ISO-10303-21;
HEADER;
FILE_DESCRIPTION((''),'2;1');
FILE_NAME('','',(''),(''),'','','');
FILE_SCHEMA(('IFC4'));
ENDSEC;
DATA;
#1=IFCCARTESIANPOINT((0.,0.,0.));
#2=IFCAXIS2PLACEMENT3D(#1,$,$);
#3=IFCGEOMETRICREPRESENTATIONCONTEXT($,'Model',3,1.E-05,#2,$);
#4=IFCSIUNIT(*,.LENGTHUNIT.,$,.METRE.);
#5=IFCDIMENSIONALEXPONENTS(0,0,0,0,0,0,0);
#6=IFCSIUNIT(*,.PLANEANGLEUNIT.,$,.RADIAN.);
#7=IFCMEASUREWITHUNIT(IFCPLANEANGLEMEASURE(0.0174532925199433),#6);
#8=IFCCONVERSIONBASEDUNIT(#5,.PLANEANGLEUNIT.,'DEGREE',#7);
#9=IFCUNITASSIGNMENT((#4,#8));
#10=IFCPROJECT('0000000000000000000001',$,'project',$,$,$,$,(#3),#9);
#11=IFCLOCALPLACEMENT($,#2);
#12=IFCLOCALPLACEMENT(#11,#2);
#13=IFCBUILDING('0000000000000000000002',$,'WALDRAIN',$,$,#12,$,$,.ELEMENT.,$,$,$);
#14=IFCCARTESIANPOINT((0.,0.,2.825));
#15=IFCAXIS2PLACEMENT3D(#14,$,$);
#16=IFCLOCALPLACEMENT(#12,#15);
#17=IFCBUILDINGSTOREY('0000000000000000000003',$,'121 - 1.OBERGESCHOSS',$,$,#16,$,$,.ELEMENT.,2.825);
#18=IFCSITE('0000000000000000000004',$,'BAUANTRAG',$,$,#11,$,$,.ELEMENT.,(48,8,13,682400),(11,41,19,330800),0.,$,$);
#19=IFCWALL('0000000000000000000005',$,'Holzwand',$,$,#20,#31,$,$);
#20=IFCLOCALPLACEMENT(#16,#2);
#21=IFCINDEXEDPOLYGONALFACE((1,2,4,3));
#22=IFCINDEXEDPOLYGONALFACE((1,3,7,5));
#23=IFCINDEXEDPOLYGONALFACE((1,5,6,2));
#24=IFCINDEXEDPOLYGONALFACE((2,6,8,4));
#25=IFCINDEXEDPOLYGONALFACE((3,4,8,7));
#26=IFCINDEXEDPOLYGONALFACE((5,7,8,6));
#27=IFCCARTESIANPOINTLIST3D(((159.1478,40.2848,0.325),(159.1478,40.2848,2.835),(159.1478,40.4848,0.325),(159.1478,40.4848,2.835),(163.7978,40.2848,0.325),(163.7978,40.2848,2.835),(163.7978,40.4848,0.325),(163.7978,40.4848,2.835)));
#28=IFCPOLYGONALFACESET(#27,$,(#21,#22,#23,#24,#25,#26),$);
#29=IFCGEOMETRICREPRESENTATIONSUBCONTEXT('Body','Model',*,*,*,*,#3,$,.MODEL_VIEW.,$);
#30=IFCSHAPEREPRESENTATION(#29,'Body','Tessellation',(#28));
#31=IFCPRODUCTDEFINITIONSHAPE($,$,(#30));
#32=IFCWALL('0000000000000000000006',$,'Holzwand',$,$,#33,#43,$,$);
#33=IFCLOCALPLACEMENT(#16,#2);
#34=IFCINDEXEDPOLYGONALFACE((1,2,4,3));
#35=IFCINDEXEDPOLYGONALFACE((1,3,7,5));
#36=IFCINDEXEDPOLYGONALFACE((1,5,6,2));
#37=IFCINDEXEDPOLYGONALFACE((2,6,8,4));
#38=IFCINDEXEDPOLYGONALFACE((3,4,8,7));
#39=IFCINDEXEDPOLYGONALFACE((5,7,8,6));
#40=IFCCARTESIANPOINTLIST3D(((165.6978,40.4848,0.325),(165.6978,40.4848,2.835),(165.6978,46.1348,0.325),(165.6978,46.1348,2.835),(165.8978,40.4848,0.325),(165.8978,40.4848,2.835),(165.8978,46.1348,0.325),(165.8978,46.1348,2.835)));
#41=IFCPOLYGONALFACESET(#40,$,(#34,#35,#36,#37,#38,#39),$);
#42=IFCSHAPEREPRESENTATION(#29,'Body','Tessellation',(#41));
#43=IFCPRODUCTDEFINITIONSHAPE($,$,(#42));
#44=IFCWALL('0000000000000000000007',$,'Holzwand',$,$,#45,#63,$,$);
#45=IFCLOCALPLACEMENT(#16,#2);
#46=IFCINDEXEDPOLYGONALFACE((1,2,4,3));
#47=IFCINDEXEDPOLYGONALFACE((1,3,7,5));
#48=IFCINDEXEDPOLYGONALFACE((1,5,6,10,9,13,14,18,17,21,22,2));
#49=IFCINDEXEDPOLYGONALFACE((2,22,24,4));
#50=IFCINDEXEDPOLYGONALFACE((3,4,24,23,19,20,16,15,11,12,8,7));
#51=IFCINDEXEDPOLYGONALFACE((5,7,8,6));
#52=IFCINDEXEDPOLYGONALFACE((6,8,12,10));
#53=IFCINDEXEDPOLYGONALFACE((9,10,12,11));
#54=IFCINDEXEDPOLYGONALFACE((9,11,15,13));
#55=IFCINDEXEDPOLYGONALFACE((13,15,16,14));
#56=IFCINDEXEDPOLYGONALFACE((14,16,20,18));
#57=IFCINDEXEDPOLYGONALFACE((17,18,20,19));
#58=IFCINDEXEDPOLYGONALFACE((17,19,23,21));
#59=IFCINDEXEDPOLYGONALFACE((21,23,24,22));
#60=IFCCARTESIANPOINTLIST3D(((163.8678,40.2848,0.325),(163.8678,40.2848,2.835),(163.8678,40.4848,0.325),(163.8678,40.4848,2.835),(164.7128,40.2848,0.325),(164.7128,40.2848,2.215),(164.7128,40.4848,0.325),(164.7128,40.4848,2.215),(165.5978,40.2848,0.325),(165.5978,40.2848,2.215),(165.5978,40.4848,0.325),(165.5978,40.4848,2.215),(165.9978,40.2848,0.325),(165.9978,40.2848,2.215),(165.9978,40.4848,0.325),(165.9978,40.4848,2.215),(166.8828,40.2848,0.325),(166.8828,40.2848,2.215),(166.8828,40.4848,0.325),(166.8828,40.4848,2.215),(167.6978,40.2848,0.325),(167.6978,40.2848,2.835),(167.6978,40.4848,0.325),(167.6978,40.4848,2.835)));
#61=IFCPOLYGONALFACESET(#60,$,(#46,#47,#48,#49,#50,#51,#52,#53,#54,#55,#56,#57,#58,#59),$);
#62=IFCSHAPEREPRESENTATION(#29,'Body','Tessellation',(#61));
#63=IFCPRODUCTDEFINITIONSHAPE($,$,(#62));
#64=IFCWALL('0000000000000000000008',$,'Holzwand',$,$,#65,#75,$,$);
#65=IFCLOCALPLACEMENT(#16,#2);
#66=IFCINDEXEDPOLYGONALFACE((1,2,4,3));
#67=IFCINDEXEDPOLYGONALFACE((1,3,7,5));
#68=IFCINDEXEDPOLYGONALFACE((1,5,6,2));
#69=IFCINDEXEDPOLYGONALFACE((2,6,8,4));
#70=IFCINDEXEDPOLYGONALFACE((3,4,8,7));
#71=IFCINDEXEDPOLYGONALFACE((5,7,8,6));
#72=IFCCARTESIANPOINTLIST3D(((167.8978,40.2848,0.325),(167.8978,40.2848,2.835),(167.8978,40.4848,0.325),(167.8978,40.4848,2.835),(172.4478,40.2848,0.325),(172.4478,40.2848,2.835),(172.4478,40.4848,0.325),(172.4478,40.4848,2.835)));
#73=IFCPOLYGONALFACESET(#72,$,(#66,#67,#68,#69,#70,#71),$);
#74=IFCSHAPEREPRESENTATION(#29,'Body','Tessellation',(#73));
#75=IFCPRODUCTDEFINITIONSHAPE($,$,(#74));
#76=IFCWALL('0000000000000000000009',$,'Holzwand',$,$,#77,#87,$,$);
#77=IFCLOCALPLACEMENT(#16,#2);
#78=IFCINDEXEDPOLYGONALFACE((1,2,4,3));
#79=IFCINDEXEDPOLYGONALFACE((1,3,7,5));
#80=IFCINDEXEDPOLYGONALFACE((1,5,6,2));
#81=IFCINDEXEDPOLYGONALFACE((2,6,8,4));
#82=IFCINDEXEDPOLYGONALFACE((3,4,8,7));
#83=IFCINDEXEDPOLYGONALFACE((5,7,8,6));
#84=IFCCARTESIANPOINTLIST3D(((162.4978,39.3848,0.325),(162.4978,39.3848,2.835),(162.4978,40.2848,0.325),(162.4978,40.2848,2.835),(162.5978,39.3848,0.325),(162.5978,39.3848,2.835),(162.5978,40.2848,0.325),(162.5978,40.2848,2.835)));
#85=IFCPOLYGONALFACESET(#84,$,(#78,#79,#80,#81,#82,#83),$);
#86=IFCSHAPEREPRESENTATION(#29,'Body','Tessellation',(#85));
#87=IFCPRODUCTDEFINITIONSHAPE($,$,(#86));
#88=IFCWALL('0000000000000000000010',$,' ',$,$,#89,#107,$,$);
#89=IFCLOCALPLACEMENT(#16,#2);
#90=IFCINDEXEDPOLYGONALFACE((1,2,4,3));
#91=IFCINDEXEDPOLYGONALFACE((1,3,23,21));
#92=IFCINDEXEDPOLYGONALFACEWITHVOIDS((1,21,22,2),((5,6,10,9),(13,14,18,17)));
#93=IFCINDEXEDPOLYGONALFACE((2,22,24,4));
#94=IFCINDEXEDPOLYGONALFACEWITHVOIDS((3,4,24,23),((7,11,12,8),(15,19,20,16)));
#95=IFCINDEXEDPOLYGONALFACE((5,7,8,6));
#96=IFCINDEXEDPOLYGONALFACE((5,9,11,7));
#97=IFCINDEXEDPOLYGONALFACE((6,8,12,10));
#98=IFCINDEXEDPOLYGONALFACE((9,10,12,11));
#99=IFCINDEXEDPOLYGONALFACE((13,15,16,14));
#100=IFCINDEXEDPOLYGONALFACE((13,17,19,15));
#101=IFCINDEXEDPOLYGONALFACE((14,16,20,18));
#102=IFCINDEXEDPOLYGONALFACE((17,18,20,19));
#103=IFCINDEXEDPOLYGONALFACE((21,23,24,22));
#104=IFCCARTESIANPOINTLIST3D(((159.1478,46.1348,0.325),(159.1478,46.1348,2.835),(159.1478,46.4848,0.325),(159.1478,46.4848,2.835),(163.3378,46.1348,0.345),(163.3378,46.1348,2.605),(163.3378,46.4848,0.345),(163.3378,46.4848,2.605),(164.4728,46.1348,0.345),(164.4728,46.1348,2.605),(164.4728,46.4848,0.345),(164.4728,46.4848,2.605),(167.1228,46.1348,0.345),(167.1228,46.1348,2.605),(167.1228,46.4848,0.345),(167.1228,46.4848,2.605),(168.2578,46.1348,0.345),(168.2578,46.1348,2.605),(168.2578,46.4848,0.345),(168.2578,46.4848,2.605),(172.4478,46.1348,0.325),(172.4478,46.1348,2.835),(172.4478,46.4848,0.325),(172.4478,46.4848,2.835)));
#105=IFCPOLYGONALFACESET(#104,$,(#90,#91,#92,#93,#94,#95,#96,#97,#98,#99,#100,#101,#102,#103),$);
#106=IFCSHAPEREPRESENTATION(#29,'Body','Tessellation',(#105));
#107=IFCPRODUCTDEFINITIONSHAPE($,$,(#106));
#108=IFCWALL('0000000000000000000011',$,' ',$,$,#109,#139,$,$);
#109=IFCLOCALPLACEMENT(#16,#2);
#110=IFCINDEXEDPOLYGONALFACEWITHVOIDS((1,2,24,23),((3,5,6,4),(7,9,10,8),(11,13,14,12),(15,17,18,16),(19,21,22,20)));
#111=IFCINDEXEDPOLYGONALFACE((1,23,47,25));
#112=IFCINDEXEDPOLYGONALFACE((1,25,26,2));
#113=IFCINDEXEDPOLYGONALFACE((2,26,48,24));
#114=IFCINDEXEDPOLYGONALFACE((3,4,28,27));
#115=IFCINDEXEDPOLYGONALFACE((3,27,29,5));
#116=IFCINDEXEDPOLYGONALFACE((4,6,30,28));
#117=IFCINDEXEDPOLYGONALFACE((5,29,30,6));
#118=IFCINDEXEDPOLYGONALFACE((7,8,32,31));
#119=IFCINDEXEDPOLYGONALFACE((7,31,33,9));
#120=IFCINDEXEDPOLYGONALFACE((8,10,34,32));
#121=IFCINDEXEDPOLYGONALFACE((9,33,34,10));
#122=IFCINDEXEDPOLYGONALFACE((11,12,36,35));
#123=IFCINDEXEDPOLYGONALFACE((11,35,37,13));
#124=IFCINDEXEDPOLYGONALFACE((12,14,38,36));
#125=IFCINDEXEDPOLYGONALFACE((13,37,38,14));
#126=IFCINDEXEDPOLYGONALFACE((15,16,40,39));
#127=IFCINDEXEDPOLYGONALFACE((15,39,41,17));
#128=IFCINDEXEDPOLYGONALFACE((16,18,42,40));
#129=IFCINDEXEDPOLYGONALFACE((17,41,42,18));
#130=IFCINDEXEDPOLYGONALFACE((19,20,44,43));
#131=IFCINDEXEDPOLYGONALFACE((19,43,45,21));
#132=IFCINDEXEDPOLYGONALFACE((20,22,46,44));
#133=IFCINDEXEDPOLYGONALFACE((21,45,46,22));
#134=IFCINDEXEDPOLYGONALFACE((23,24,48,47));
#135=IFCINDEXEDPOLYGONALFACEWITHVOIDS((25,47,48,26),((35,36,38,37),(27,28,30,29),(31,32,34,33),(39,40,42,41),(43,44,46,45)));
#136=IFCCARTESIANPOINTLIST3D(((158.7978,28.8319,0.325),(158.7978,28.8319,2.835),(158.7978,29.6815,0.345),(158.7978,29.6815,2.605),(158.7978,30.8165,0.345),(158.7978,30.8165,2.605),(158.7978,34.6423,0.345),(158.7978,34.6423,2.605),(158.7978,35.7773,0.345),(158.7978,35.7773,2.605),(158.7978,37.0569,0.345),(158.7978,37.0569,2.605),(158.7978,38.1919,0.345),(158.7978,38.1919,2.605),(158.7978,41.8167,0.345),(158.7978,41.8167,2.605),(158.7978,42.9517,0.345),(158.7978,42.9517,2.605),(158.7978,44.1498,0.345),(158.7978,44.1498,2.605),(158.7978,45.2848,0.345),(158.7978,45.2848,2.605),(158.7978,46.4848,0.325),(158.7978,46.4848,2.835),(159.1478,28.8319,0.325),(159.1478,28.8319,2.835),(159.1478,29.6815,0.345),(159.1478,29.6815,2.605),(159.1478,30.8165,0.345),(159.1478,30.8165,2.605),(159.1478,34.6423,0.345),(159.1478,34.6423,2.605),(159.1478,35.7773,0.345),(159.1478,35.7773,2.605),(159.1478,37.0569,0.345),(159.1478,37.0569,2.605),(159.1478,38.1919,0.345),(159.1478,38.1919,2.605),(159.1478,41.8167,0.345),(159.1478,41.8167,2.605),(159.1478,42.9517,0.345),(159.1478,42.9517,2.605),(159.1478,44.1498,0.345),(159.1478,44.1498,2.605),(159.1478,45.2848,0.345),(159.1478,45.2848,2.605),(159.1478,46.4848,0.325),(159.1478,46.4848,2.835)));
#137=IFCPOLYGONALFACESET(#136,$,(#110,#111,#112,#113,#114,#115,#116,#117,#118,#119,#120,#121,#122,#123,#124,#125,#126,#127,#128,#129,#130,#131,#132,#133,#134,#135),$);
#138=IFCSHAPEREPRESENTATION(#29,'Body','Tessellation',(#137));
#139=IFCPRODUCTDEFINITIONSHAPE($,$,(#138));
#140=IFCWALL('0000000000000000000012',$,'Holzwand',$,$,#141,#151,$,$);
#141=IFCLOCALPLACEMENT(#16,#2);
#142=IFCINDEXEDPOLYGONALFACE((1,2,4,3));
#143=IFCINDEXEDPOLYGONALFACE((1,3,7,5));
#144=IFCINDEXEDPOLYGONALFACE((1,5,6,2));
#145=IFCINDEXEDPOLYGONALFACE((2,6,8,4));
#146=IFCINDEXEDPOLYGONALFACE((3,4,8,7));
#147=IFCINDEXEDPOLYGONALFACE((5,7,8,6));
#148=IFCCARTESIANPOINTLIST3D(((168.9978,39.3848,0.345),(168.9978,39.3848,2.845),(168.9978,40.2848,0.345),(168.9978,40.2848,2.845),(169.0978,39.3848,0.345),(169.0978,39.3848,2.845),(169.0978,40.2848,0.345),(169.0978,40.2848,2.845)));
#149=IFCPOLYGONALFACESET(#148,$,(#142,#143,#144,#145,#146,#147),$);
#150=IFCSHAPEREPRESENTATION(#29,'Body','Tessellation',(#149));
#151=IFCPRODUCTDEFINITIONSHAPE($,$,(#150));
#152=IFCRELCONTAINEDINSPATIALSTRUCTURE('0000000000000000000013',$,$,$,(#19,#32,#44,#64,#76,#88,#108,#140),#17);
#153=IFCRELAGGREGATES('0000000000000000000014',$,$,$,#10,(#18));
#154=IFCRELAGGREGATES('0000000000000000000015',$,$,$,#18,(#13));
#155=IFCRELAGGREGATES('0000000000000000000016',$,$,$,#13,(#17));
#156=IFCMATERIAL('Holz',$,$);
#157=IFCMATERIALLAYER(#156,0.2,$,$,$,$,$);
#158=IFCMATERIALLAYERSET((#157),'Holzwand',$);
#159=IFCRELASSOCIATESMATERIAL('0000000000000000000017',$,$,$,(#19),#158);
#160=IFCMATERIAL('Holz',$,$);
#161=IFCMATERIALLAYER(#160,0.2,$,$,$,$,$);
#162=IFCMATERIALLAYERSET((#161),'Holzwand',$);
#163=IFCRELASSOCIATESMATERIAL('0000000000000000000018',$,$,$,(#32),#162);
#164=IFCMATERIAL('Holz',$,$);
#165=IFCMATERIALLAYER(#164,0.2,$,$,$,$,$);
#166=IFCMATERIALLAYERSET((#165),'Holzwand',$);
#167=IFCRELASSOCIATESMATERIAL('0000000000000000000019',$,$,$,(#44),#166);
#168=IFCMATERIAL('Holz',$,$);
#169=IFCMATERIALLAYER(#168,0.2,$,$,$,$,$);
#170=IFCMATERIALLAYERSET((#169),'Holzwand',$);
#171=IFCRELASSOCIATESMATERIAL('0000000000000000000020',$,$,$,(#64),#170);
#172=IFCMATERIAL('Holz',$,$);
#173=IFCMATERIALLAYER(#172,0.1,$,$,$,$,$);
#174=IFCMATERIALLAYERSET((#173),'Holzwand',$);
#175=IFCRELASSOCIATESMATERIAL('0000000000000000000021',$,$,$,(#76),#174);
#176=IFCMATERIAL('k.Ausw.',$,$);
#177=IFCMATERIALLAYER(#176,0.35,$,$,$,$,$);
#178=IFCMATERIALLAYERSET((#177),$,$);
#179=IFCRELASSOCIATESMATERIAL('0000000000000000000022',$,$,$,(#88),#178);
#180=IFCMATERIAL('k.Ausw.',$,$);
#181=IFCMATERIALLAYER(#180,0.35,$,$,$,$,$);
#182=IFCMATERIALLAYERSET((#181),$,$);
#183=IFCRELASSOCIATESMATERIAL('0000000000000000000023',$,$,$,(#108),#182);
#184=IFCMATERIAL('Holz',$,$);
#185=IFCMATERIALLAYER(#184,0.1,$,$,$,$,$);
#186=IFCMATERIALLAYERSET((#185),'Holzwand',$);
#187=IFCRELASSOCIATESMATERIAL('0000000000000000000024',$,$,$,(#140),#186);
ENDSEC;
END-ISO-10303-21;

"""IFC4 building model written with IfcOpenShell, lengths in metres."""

from ifc_helpers import new_model, entity, si_unit, converted_unit, frame, frame_2d, origin, origin_with_axes, place, context, subcontext, project, spatial, polyline, rectangle, outline, extrude, material, layer, layer_set, layer_usage, element, save


model = new_model("IFC4")

# Units and contexts
model_context = context("Model", 3, precision=1e-05, world=origin())
body_context = subcontext(model_context, "Body", "Model", "MODEL_VIEW")
ifc_project = project(units=[si_unit("LENGTHUNIT", "METRE"), converted_unit("PLANEANGLEUNIT", "DEGREE", entity("IfcPlaneAngleMeasure", 0.0174532925199433), si_unit("PLANEANGLEUNIT", "RADIAN"), dimensions=[0, 0, 0, 0, 0, 0, 0])], contexts=[model_context])

# Site, building, storey
site_placement = place(None, origin())
site = spatial("IfcSite", under=ifc_project, at=site_placement, Name="BAUANTRAG", CompositionType="ELEMENT", RefLatitude=(48, 8, 13, 682400), RefLongitude=(11, 41, 19, 330800), RefElevation=0.0)
building_placement = place(site_placement, origin())
building = spatial("IfcBuilding", under=site, at=building_placement, Name="WALDRAIN", CompositionType="ELEMENT")
storey_placement = place(building_placement, frame((0.0, 0.0, 2.825)))
storey = spatial("IfcBuildingStorey", under=building, at=storey_placement, Name="121 - 1.OBERGESCHOSS", CompositionType="ELEMENT", Elevation=2.825)

# Walls
ifc_material_1 = material(Name="Holz")
ifc_layer_1 = layer(ifc_material_1, 0.2)
ifc_layer_set_1 = layer_set([ifc_layer_1], Name="Holzwand")
ifc_layer_usage_1 = layer_usage(ifc_layer_set_1, "AXIS2", "POSITIVE", 0.0)
wall_1_placement = place(storey_placement, frame((163.7978, 40.4848, 0.325), z_axis=(0.0, 0.0, 1.0), x_axis=(-1.0, 0.0, 0.0)))
element("IfcWall", 1, at=wall_1_placement, inside=storey, material=ifc_layer_usage_1, Name="Holzwand", context=body_context, shape_type="SweptSolid", body=[
    extrude(rectangle(XDim=4.65, YDim=0.2, at=frame_2d((2.325, 0.1), x_axis=(1.0, 0.0))), origin_with_axes(), (0.0, 0.0, 1.0), 2.51),
])
ifc_material_2 = material(Name="Holz")
ifc_layer_2 = layer(ifc_material_2, 0.2)
ifc_layer_set_2 = layer_set([ifc_layer_2], Name="Holzwand")
ifc_layer_usage_2 = layer_usage(ifc_layer_set_2, "AXIS2", "POSITIVE", 0.0)
wall_2_placement = place(storey_placement, frame((165.6978, 46.1348, 0.325), z_axis=(0.0, 0.0, 1.0), x_axis=(0.0, -1.0, 0.0)))
element("IfcWall", 2, at=wall_2_placement, inside=storey, material=ifc_layer_usage_2, Name="Holzwand", context=body_context, shape_type="SweptSolid", body=[
    extrude(rectangle(XDim=5.65, YDim=0.2, at=frame_2d((2.825, 0.1), x_axis=(1.0, 0.0))), origin_with_axes(), (0.0, 0.0, 1.0), 2.51),
])

# Wall, openings
ifc_material_3 = material(Name="Holz")
ifc_layer_3 = layer(ifc_material_3, 0.2)
ifc_layer_set_3 = layer_set([ifc_layer_3], Name="Holzwand")
ifc_layer_usage_3 = layer_usage(ifc_layer_set_3, "AXIS2", "POSITIVE", 0.0)
wall_3_placement = place(storey_placement, frame((167.6978, 40.4848, 0.325), z_axis=(0.0, 0.0, 1.0), x_axis=(-1.0, 0.0, 0.0)))
wall_3 = element("IfcWall", 3, at=wall_3_placement, inside=storey, material=ifc_layer_usage_3, Name="Holzwand", context=body_context, shape_type="SweptSolid", body=[
    extrude(rectangle(XDim=3.83, YDim=0.2, at=frame_2d((1.915, 0.1), x_axis=(1.0, 0.0))), origin_with_axes(), (0.0, 0.0, 1.0), 2.51),
])
opening_1_placement = place(wall_3_placement, frame((0.815, 0.0, -0.12), z_axis=(0.0, 1.0, 0.0), x_axis=(0.0, 0.0, 1.0)))
element("IfcOpeningElement", 4, at=opening_1_placement, cuts=wall_3, ObjectType="Opening", context=body_context, shape_type="SweptSolid", body=[
    extrude(outline(polyline([(0.0, 0.885), (2.01, 0.885), (2.01, 0.0), (0.0, 0.0), (0.0, 0.885)])), origin_with_axes(), (0.0, 0.0, 1.0), 0.2),
])
opening_2_placement = place(wall_3_placement, frame((2.1, 0.0, -0.12), z_axis=(0.0, 1.0, 0.0), x_axis=(0.0, 0.0, 1.0)))
element("IfcOpeningElement", 5, at=opening_2_placement, cuts=wall_3, ObjectType="Opening", context=body_context, shape_type="SweptSolid", body=[
    extrude(outline(polyline([(0.0, 0.885), (2.01, 0.885), (2.01, 0.0), (0.0, 0.0), (0.0, 0.885)])), origin_with_axes(), (0.0, 0.0, 1.0), 0.2),
])

# Walls
ifc_material_4 = material(Name="Holz")
ifc_layer_4 = layer(ifc_material_4, 0.2)
ifc_layer_set_4 = layer_set([ifc_layer_4], Name="Holzwand")
ifc_layer_usage_4 = layer_usage(ifc_layer_set_4, "AXIS2", "POSITIVE", 0.0)
wall_4_placement = place(storey_placement, frame((172.4478, 40.4848, 0.325), z_axis=(0.0, 0.0, 1.0), x_axis=(-1.0, 0.0, 0.0)))
element("IfcWall", 6, at=wall_4_placement, inside=storey, material=ifc_layer_usage_4, Name="Holzwand", context=body_context, shape_type="SweptSolid", body=[
    extrude(rectangle(XDim=4.55, YDim=0.2, at=frame_2d((2.275, 0.1), x_axis=(1.0, 0.0))), origin_with_axes(), (0.0, 0.0, 1.0), 2.51),
])
ifc_material_5 = material(Name="Holz")
ifc_layer_5 = layer(ifc_material_5, 0.1)
ifc_layer_set_5 = layer_set([ifc_layer_5], Name="Holzwand")
ifc_layer_usage_5 = layer_usage(ifc_layer_set_5, "AXIS2", "POSITIVE", 0.0)
wall_5_placement = place(storey_placement, frame((162.4978, 40.2848, 0.325), z_axis=(0.0, 0.0, 1.0), x_axis=(0.0, -1.0, 0.0)))
element("IfcWall", 7, at=wall_5_placement, inside=storey, material=ifc_layer_usage_5, Name="Holzwand", context=body_context, shape_type="SweptSolid", body=[
    extrude(rectangle(XDim=0.9, YDim=0.1, at=frame_2d((0.45, 0.05), x_axis=(1.0, 0.0))), origin_with_axes(), (0.0, 0.0, 1.0), 2.51),
])

# Walls, openings
ifc_material_6 = material(Name="k.Ausw.")
ifc_layer_6 = layer(ifc_material_6, 0.35)
ifc_layer_set_6 = layer_set([ifc_layer_6])
ifc_layer_usage_6 = layer_usage(ifc_layer_set_6, "AXIS2", "POSITIVE", 0.0)
wall_6_placement = place(storey_placement, frame((172.4478, 46.4848, 0.325), z_axis=(0.0, 0.0, 1.0), x_axis=(-1.0, 0.0, 0.0)))
wall_6 = element("IfcWall", 8, at=wall_6_placement, inside=storey, material=ifc_layer_usage_6, Name=" ", context=body_context, shape_type="SweptSolid", body=[
    extrude(rectangle(XDim=13.3, YDim=0.35, at=frame_2d((6.65, 0.175), x_axis=(1.0, 0.0))), origin_with_axes(), (0.0, 0.0, 1.0), 2.51),
])
opening_3_placement = place(wall_6_placement, frame((9.11, 0.35, 0.02), z_axis=(0.0, -1.0, 0.0), x_axis=(0.0, 0.0, 1.0)))
element("IfcOpeningElement", 9, at=opening_3_placement, cuts=wall_6, ObjectType="Opening", context=body_context, shape_type="SweptSolid", body=[
    extrude(outline(polyline([(0.0, 1.135), (2.26, 1.135), (2.26, 0.0), (0.0, 0.0), (0.0, 1.135)])), origin_with_axes(), (0.0, 0.0, 1.0), 0.35),
])
opening_4_placement = place(wall_6_placement, frame((5.325, 0.35, 0.02), z_axis=(0.0, -1.0, 0.0), x_axis=(0.0, 0.0, 1.0)))
element("IfcOpeningElement", 10, at=opening_4_placement, cuts=wall_6, ObjectType="Opening", context=body_context, shape_type="SweptSolid", body=[
    extrude(outline(polyline([(0.0, 1.135), (2.26, 1.135), (2.26, 0.0), (0.0, 0.0), (0.0, 1.135)])), origin_with_axes(), (0.0, 0.0, 1.0), 0.35),
])
ifc_material_7 = material(Name="k.Ausw.")
ifc_layer_7 = layer(ifc_material_7, 0.35)
ifc_layer_set_7 = layer_set([ifc_layer_7])
ifc_layer_usage_7 = layer_usage(ifc_layer_set_7, "AXIS2", "POSITIVE", 0.0)
wall_7_placement = place(storey_placement, frame((158.7978, 46.4848, 0.325), z_axis=(0.0, 0.0, 1.0), x_axis=(0.0, -1.0, 0.0)))
wall_7 = element("IfcWall", 11, at=wall_7_placement, inside=storey, material=ifc_layer_usage_7, Name=" ", context=body_context, shape_type="SweptSolid", body=[
    extrude(rectangle(XDim=17.6529, YDim=0.35, at=frame_2d((8.8264, 0.175), x_axis=(1.0, 0.0))), origin_with_axes(), (0.0, 0.0, 1.0), 2.51),
])
opening_5_placement = place(wall_7_placement, frame((11.8425, 0.35, 0.02), z_axis=(0.0, -1.0, 0.0), x_axis=(0.0, 0.0, 1.0)))
element("IfcOpeningElement", 12, at=opening_5_placement, cuts=wall_7, ObjectType="Opening", context=body_context, shape_type="SweptSolid", body=[
    extrude(outline(polyline([(0.0, 1.135), (2.26, 1.135), (2.26, 0.0), (0.0, 0.0), (0.0, 1.135)])), origin_with_axes(), (0.0, 0.0, 1.0), 0.35),
])
opening_6_placement = place(wall_7_placement, frame((9.4279, 0.35, 0.02), z_axis=(0.0, -1.0, 0.0), x_axis=(0.0, 0.0, 1.0)))
element("IfcOpeningElement", 13, at=opening_6_placement, cuts=wall_7, ObjectType="Opening", context=body_context, shape_type="SweptSolid", body=[
    extrude(outline(polyline([(0.0, 1.135), (2.26, 1.135), (2.26, 0.0), (0.0, 0.0), (0.0, 1.135)])), origin_with_axes(), (0.0, 0.0, 1.0), 0.35),
])
opening_7_placement = place(wall_7_placement, frame((16.8033, 0.35, 0.02), z_axis=(0.0, -1.0, 0.0), x_axis=(0.0, 0.0, 1.0)))
element("IfcOpeningElement", 14, at=opening_7_placement, cuts=wall_7, ObjectType="Opening", context=body_context, shape_type="SweptSolid", body=[
    extrude(outline(polyline([(0.0, 1.135), (2.26, 1.135), (2.26, 0.0), (0.0, 0.0), (0.0, 1.135)])), origin_with_axes(), (0.0, 0.0, 1.0), 0.35),
])
opening_8_placement = place(wall_7_placement, frame((4.6681, 0.35, 0.02), z_axis=(0.0, -1.0, 0.0), x_axis=(0.0, 0.0, 1.0)))
element("IfcOpeningElement", 15, at=opening_8_placement, cuts=wall_7, ObjectType="Opening", context=body_context, shape_type="SweptSolid", body=[
    extrude(outline(polyline([(0.0, 1.135), (2.26, 1.135), (2.26, 0.0), (0.0, 0.0), (0.0, 1.135)])), origin_with_axes(), (0.0, 0.0, 1.0), 0.35),
])
opening_9_placement = place(wall_7_placement, frame((2.335, 0.35, 0.02), z_axis=(0.0, -1.0, 0.0), x_axis=(0.0, 0.0, 1.0)))
element("IfcOpeningElement", 16, at=opening_9_placement, cuts=wall_7, ObjectType="Opening", context=body_context, shape_type="SweptSolid", body=[
    extrude(outline(polyline([(0.0, 1.135), (2.26, 1.135), (2.26, 0.0), (0.0, 0.0), (0.0, 1.135)])), origin_with_axes(), (0.0, 0.0, 1.0), 0.35),
])

# Wall
ifc_material_8 = material(Name="Holz")
ifc_layer_8 = layer(ifc_material_8, 0.1)
ifc_layer_set_8 = layer_set([ifc_layer_8], Name="Holzwand")
ifc_layer_usage_8 = layer_usage(ifc_layer_set_8, "AXIS2", "POSITIVE", 0.0)
wall_8_placement = place(storey_placement, frame((168.9978, 40.2848, 0.345), z_axis=(0.0, 0.0, 1.0), x_axis=(0.0, -1.0, 0.0)))
element("IfcWall", 17, at=wall_8_placement, inside=storey, material=ifc_layer_usage_8, Name="Holzwand", context=body_context, shape_type="SweptSolid", body=[
    extrude(rectangle(XDim=0.9, YDim=0.1, at=frame_2d((0.45, 0.05), x_axis=(1.0, 0.0))), origin_with_axes(), (0.0, 0.0, 1.0), 2.5),
])

save(model, "model.ifc")
